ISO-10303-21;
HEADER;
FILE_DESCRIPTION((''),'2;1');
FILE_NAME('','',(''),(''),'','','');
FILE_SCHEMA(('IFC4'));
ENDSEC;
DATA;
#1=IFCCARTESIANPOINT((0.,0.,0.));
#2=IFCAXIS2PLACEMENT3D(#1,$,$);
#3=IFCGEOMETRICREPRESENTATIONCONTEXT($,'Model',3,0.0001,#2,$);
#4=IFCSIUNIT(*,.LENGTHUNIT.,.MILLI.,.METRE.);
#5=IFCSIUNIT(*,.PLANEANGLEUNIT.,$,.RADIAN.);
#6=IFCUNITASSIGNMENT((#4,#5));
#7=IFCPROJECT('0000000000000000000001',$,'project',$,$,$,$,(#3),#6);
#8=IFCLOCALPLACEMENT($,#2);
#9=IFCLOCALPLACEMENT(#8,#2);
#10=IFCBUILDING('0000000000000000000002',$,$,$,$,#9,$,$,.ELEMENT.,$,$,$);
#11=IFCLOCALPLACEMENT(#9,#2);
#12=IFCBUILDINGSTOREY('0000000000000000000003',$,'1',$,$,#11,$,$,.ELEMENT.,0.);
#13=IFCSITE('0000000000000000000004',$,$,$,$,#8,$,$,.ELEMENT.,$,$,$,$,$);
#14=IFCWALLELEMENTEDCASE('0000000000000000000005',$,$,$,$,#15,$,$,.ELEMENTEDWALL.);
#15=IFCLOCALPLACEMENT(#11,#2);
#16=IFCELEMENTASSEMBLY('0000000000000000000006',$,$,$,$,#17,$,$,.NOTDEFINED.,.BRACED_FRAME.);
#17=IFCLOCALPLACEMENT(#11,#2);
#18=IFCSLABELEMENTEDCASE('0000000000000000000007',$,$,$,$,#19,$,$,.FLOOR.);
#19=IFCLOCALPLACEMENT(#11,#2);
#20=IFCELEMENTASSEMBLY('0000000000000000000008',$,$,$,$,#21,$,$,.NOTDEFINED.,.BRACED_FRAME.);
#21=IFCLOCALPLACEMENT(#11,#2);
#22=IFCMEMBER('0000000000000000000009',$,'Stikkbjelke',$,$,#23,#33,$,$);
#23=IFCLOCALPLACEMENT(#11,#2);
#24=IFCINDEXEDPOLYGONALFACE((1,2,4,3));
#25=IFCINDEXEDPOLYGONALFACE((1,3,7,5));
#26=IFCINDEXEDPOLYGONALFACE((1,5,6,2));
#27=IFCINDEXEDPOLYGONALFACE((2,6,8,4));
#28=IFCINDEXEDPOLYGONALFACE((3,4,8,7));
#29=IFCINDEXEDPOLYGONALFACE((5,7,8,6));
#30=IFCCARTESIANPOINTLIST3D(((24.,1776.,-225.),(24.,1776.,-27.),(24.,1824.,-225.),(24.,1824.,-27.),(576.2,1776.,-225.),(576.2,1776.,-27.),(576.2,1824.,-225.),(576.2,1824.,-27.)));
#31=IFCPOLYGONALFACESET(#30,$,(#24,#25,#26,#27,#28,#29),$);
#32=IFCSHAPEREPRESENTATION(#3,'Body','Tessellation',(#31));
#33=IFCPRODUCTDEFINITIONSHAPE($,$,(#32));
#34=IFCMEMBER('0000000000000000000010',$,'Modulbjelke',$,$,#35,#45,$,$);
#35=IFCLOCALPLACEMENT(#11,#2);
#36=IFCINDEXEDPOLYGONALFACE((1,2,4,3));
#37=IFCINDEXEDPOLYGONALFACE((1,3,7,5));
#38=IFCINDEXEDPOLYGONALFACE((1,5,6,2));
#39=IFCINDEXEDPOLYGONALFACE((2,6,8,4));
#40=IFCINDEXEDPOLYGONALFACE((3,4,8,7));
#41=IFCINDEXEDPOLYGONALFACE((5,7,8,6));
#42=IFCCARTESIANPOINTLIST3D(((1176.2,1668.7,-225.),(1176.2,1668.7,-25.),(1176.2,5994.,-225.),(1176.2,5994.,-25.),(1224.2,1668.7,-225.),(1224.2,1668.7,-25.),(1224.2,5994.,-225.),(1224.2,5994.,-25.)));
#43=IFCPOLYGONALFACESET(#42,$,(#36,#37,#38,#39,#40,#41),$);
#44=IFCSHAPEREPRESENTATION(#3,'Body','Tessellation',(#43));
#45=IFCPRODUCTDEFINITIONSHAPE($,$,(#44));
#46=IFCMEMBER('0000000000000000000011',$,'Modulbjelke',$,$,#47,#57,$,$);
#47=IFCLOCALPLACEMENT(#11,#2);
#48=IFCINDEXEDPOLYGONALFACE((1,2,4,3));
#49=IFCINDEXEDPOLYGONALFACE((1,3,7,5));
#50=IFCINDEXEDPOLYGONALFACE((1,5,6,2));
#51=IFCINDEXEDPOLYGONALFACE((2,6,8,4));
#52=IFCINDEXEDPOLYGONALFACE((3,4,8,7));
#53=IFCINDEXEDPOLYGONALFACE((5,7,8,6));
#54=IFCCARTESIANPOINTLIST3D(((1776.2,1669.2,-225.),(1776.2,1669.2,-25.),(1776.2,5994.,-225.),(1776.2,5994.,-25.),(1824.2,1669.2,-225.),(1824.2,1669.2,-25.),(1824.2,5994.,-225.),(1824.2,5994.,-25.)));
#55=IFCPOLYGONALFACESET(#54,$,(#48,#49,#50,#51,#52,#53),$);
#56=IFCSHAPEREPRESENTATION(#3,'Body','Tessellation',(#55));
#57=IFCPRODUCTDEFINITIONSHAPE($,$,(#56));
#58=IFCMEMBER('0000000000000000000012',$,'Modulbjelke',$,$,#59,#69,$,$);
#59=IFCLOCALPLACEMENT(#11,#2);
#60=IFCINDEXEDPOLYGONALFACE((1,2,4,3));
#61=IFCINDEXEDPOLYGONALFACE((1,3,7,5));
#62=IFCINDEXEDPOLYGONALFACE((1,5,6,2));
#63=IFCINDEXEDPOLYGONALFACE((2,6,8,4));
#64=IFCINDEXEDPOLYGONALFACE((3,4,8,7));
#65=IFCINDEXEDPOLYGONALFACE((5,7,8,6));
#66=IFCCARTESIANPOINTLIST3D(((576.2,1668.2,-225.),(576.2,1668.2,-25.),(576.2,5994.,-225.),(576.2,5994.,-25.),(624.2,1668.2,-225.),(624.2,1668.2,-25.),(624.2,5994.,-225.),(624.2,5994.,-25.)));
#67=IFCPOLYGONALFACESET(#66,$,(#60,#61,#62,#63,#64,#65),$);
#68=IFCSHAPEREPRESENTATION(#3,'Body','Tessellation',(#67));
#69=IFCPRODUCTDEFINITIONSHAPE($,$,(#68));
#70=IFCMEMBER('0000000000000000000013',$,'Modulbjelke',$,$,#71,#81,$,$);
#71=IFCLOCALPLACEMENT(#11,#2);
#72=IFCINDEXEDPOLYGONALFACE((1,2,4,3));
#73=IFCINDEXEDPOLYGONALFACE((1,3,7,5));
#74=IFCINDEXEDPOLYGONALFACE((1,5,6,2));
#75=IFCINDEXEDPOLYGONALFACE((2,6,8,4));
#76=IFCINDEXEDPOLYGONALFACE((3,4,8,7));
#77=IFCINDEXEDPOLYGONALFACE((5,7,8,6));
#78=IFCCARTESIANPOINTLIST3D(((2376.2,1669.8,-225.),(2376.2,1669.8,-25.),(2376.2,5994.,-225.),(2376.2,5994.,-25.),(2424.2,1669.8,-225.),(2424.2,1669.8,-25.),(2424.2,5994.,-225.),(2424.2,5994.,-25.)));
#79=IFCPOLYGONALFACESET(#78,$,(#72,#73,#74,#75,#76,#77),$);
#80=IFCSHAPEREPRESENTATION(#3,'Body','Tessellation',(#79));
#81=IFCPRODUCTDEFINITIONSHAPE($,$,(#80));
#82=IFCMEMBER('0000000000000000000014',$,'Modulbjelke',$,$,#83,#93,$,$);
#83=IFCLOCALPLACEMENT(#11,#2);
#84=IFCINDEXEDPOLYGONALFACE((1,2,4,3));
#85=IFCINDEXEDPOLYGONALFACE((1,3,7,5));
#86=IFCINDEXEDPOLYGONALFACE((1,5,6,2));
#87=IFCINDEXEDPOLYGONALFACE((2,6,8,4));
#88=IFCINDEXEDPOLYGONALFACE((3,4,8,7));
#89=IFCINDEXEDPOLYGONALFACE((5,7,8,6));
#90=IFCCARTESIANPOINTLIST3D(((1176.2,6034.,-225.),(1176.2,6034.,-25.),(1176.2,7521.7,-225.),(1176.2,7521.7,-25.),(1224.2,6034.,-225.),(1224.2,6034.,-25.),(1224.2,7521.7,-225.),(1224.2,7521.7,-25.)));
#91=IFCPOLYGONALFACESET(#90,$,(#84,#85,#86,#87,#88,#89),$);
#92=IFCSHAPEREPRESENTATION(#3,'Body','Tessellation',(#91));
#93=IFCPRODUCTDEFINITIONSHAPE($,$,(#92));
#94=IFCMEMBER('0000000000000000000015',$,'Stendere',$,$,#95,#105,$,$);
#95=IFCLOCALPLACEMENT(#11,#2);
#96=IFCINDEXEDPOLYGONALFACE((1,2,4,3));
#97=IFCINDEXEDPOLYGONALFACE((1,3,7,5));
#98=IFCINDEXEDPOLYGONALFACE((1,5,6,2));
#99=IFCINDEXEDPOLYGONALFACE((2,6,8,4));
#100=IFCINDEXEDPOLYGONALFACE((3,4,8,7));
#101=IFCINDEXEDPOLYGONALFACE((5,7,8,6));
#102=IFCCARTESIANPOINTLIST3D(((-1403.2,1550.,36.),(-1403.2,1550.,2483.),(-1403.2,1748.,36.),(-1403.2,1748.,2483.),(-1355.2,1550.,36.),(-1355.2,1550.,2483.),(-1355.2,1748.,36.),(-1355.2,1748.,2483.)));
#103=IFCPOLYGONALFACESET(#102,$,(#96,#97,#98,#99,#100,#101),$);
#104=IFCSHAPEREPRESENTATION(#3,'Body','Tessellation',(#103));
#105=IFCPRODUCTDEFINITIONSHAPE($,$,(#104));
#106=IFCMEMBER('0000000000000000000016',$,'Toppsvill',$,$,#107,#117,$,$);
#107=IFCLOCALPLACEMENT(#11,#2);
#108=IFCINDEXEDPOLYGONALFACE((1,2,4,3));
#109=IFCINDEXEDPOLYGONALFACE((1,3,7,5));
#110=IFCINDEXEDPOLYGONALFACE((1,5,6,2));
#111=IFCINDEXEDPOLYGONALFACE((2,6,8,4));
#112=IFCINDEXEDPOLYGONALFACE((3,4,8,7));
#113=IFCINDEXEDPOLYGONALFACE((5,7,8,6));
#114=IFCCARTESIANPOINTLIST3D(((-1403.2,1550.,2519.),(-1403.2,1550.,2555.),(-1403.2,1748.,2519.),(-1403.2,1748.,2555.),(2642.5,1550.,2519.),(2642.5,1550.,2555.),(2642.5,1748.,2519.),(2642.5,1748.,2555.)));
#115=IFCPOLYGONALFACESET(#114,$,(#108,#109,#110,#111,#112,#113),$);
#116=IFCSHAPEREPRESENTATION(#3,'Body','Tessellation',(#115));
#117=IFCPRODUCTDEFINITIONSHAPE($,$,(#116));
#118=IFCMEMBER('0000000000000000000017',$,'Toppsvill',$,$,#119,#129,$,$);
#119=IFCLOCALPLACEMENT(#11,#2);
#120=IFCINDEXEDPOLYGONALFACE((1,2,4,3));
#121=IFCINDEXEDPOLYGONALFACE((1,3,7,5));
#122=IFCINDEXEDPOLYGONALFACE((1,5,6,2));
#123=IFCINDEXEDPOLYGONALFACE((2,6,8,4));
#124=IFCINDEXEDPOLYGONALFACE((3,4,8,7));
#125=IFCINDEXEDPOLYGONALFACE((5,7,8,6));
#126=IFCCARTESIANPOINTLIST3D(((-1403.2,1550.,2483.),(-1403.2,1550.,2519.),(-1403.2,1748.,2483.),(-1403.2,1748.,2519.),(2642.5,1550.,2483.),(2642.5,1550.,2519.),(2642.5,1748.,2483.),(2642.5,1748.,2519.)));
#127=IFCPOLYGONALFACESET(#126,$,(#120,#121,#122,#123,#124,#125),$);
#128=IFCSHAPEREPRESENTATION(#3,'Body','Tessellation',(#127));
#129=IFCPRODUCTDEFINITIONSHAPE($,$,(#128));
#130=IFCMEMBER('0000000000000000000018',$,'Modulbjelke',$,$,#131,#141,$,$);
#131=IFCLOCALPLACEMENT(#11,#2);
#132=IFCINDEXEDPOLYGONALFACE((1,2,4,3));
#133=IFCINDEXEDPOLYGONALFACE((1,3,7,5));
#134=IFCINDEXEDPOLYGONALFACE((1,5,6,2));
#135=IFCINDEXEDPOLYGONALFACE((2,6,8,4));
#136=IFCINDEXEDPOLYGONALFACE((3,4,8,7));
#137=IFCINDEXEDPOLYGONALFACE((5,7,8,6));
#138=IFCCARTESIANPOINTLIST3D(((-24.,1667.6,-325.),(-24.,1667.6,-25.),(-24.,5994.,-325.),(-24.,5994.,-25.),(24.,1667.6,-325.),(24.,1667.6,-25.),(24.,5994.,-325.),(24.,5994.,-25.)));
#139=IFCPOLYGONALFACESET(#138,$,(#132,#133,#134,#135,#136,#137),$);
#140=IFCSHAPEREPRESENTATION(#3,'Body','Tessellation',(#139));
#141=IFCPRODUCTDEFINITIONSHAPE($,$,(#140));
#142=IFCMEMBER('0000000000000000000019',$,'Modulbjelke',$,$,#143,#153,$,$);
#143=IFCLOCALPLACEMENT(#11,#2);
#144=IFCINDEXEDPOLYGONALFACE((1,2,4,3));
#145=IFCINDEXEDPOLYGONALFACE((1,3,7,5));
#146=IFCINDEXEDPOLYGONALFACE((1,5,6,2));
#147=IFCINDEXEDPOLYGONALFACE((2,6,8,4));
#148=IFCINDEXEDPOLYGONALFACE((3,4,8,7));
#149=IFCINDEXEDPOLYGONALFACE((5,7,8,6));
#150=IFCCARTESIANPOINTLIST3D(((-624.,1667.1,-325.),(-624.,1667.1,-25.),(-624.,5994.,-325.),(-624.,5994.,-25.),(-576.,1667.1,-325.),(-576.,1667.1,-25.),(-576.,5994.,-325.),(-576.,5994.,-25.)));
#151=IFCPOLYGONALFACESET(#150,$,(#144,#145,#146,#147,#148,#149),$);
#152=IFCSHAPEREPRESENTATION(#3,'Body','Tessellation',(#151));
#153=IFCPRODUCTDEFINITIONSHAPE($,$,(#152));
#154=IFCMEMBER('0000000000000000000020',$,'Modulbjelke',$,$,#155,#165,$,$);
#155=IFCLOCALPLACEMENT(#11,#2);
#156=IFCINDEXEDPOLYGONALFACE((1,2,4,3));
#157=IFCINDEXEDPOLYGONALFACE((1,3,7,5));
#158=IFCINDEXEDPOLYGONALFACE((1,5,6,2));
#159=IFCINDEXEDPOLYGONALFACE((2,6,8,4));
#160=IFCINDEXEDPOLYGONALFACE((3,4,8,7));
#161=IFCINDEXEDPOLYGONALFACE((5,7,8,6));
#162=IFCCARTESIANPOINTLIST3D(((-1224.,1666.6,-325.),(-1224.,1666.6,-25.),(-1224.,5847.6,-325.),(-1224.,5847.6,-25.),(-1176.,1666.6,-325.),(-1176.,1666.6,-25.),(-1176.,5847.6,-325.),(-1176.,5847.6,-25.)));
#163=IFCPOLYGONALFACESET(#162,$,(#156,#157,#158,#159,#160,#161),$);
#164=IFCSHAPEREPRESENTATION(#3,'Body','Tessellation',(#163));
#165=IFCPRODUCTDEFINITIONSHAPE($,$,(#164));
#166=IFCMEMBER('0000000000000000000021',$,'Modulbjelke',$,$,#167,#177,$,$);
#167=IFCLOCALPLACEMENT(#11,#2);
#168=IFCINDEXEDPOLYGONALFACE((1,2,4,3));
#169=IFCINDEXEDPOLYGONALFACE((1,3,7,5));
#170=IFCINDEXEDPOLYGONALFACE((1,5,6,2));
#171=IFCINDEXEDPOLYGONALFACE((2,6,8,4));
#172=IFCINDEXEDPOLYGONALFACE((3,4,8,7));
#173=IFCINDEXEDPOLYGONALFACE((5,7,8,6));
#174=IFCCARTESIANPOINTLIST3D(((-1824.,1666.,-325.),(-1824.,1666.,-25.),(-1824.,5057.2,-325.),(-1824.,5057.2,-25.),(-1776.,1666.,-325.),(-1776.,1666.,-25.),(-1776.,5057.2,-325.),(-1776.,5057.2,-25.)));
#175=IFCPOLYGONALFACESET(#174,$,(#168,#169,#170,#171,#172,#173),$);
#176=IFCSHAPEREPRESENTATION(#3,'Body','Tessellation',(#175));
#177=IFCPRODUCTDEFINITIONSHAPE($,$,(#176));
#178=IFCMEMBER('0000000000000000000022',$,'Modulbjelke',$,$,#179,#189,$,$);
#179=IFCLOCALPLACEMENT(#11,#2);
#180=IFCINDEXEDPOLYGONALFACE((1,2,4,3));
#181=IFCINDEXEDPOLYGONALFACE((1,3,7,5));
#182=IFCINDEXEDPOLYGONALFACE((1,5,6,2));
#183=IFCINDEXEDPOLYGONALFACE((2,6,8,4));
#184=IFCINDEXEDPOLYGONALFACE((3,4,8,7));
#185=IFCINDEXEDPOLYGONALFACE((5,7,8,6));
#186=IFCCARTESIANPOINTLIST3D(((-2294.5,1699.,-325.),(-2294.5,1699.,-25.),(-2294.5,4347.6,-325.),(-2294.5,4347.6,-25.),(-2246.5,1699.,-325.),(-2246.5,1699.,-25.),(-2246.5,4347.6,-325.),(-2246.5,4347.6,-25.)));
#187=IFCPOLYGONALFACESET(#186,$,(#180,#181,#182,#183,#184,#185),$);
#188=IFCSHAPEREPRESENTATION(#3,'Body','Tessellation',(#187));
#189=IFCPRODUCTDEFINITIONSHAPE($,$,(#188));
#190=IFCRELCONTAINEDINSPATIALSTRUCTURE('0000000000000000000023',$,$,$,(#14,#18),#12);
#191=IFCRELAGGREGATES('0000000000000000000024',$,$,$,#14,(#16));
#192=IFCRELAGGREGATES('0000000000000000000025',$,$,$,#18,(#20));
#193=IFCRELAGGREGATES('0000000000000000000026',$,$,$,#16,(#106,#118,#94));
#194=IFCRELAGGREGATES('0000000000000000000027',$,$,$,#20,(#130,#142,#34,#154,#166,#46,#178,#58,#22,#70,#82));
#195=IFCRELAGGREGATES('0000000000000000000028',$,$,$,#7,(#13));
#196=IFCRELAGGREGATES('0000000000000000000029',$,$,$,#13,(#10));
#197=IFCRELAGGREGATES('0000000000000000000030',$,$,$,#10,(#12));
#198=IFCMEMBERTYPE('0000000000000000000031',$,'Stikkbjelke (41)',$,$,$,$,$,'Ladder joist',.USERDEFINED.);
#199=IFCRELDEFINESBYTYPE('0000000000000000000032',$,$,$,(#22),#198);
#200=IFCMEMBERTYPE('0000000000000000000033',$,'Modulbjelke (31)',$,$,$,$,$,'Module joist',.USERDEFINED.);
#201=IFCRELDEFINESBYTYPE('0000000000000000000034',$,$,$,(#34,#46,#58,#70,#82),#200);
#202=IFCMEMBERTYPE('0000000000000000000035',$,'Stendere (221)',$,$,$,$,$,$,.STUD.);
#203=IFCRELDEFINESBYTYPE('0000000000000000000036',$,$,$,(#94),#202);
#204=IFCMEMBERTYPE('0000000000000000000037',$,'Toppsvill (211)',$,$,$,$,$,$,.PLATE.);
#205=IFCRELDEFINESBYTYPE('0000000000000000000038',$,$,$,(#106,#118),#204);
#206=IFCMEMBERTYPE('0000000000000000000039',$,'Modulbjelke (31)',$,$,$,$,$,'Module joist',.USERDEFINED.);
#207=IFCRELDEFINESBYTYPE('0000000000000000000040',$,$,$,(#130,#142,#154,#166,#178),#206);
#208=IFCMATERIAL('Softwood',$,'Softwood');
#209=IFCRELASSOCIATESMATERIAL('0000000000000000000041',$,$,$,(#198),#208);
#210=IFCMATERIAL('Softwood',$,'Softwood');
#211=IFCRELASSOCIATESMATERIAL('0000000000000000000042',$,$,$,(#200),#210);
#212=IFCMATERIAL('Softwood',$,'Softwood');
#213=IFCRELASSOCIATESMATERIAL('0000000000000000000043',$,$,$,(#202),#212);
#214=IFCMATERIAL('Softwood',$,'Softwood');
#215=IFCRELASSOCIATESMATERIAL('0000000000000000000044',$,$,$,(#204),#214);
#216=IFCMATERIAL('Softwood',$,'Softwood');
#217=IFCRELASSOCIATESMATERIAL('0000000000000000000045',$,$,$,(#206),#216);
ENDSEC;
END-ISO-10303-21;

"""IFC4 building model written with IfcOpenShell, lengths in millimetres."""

from ifc_helpers import new_model, si_unit, frame, origin, place, context, project, spatial, rectangle, extrude, clip, halfspace, material, material_profile, profile_set, type_object, element, aggregate, save


model = new_model("IFC4")

# Units and contexts
model_context = context("Model", 3, precision=0.0001, world=origin())
ifc_project = project(units=[si_unit("LENGTHUNIT", "METRE", prefix="MILLI"), si_unit("PLANEANGLEUNIT", "RADIAN")], contexts=[model_context])

# Site, building, storey
site_placement = place(None, origin())
site = spatial("IfcSite", under=ifc_project, at=site_placement, CompositionType="ELEMENT")
building_placement = place(site_placement, origin())
building = spatial("IfcBuilding", under=site, at=building_placement, CompositionType="ELEMENT")
storey_placement = place(building_placement, origin())
storey = spatial("IfcBuildingStorey", under=building, at=storey_placement, Name="1", CompositionType="ELEMENT", Elevation=0.0)

# Wall, element assembly
wall_placement = place(storey_placement, frame((-1403.2, 1748.0, 0.0), z_axis=(0.0, -1.0, 0.0)))
wall = element("IfcWallElementedCase", 1, at=wall_placement, inside=storey, PredefinedType="ELEMENTEDWALL")
assembly_1_placement = place(wall_placement, origin())
assembly_1 = element("IfcElementAssembly", 2, at=assembly_1_placement, AssemblyPlace="NOTDEFINED", PredefinedType="BRACED_FRAME")
aggregate(wall, [assembly_1])

# Slab, element assembly, members
slab_placement = place(storey_placement, origin())
slab = element("IfcSlabElementedCase", 3, at=slab_placement, inside=storey, PredefinedType="FLOOR")
assembly_2_placement = place(slab_placement, frame((0.0, 0.0, -225.0)))
assembly_2 = element("IfcElementAssembly", 4, at=assembly_2_placement, AssemblyPlace="NOTDEFINED", PredefinedType="BRACED_FRAME")
aggregate(slab, [assembly_2])
ifc_material_1 = material(Name="Softwood", Category="Softwood")
ifc_material_profile_1 = material_profile(ifc_material_1, rectangle(XDim=48.0, YDim=198.0), Name="Stikkbjelke (41)")
ifc_profile_set_1 = profile_set([ifc_material_profile_1])
member_type_1 = type_object("IfcMemberType", Name="Stikkbjelke (41)", ElementType="Ladder joist", PredefinedType="USERDEFINED", material=ifc_profile_set_1)
member_1_placement = place(assembly_2_placement, frame((24.0, 1800.0, 0.0), z_axis=(1.0, 0.0, 0.0), x_axis=(0.0, 1.0, 0.0)))
member_1 = element("IfcMember", 5, at=member_1_placement, type_object=member_type_1, Name="Stikkbjelke", context=model_context, shape_type="SweptSolid", body=[
    extrude(rectangle(XDim=48.0, YDim=198.0), frame((0.0, 99.0, 0.0)), (0.0, 0.0, 1.0), 552.2),
])
ifc_material_2 = material(Name="Softwood", Category="Softwood")
ifc_material_profile_2 = material_profile(ifc_material_2, rectangle(XDim=48.0, YDim=200.0), Name="Modulbjelke (31)")
ifc_profile_set_2 = profile_set([ifc_material_profile_2])
member_type_2 = type_object("IfcMemberType", Name="Modulbjelke (31)", ElementType="Module joist", PredefinedType="USERDEFINED", material=ifc_profile_set_2)
member_2_placement = place(assembly_2_placement, frame((1200.2, 1668.7, 0.0), z_axis=(0.0, 1.0, 0.0), x_axis=(-1.0, 0.0, 0.0)))
member_2 = element("IfcMember", 6, at=member_2_placement, type_object=member_type_2, Name="Modulbjelke", context=model_context, shape_type="SweptSolid", body=[
    extrude(rectangle(XDim=48.0, YDim=200.0), frame((0.0, 100.0, 0.0)), (0.0, 0.0, 1.0), 4325.3),
])
member_3_placement = place(assembly_2_placement, frame((1800.2, 1669.2, 0.0), z_axis=(0.0, 1.0, 0.0), x_axis=(-1.0, 0.0, 0.0)))
member_3 = element("IfcMember", 7, at=member_3_placement, type_object=member_type_2, Name="Modulbjelke", context=model_context, shape_type="SweptSolid", body=[
    extrude(rectangle(XDim=48.0, YDim=200.0), frame((0.0, 100.0, 0.0)), (0.0, 0.0, 1.0), 4324.8),
])
member_4_placement = place(assembly_2_placement, frame((600.2, 1668.2, 0.0), z_axis=(0.0, 1.0, 0.0), x_axis=(-1.0, 0.0, 0.0)))
member_4 = element("IfcMember", 8, at=member_4_placement, type_object=member_type_2, Name="Modulbjelke", context=model_context, shape_type="SweptSolid", body=[
    extrude(rectangle(XDim=48.0, YDim=200.0), frame((0.0, 100.0, 0.0)), (0.0, 0.0, 1.0), 4325.8),
])
member_5_placement = place(assembly_2_placement, frame((2400.2, 1669.8, 0.0), z_axis=(0.0, 1.0, 0.0), x_axis=(-1.0, 0.0, 0.0)))
member_5 = element("IfcMember", 9, at=member_5_placement, type_object=member_type_2, Name="Modulbjelke", context=model_context, shape_type="SweptSolid", body=[
    extrude(rectangle(XDim=48.0, YDim=200.0), frame((0.0, 100.0, 0.0)), (0.0, 0.0, 1.0), 4324.2),
])
member_6_placement = place(assembly_2_placement, frame((1200.2, 6034.0, 0.0), z_axis=(0.000001, 1.0, 0.0), x_axis=(-1.0, 0.000001, 0.0)))
member_6 = element("IfcMember", 10, at=member_6_placement, type_object=member_type_2, Name="Modulbjelke", context=model_context, shape_type="Clipping", body=[
    clip(clip(extrude(rectangle(XDim=48.0, YDim=200.0), frame((0.0, 100.0, 0.0)), (0.0, 0.0, 1.0), 1487.7), halfspace(frame((0.0, 100.0, 0.0)), True)), halfspace(frame((0.0, 100.0, 1487.7)), False)),
])

# Members
ifc_material_3 = material(Name="Softwood", Category="Softwood")
ifc_material_profile_3 = material_profile(ifc_material_3, rectangle(XDim=48.0, YDim=198.0), Name="Stendere (221)")
ifc_profile_set_3 = profile_set([ifc_material_profile_3])
member_type_3 = type_object("IfcMemberType", Name="Stendere (221)", PredefinedType="STUD", material=ifc_profile_set_3)
member_7_placement = place(assembly_1_placement, frame((24.0, 36.0, 0.0), z_axis=(0.0, 1.0, 0.0), x_axis=(-1.0, 0.0, 0.0)))
member_7 = element("IfcMember", 11, at=member_7_placement, type_object=member_type_3, Name="Stendere", context=model_context, shape_type="SweptSolid", body=[
    extrude(rectangle(XDim=48.0, YDim=198.0), frame((0.0, 99.0, 0.0)), (0.0, 0.0, 1.0), 2447.0),
])
ifc_material_4 = material(Name="Softwood", Category="Softwood")
ifc_material_profile_4 = material_profile(ifc_material_4, rectangle(XDim=36.0, YDim=198.0), Name="Toppsvill (211)")
ifc_profile_set_4 = profile_set([ifc_material_profile_4])
member_type_4 = type_object("IfcMemberType", Name="Toppsvill (211)", PredefinedType="PLATE", material=ifc_profile_set_4)
member_8_placement = place(assembly_1_placement, frame((0.0, 2537.0, 0.0), z_axis=(1.0, 0.0, 0.0), x_axis=(0.0, 1.0, 0.0)))
member_8 = element("IfcMember", 12, at=member_8_placement, type_object=member_type_4, Name="Toppsvill", context=model_context, shape_type="SweptSolid", body=[
    extrude(rectangle(XDim=36.0, YDim=198.0), frame((0.0, 99.0, 0.0)), (0.0, 0.0, 1.0), 4045.7),
])
member_9_placement = place(assembly_1_placement, frame((0.0, 2501.0, 0.0), z_axis=(1.0, 0.0, 0.0), x_axis=(0.0, 1.0, 0.0)))
member_9 = element("IfcMember", 13, at=member_9_placement, type_object=member_type_4, Name="Toppsvill", context=model_context, shape_type="SweptSolid", body=[
    extrude(rectangle(XDim=36.0, YDim=198.0), frame((0.0, 99.0, 0.0)), (0.0, 0.0, 1.0), 4045.7),
])
aggregate(assembly_1, [member_8, member_9, member_7])
ifc_material_5 = material(Name="Softwood", Category="Softwood")
ifc_material_profile_5 = material_profile(ifc_material_5, rectangle(XDim=48.0, YDim=300.0), Name="Modulbjelke (31)")
ifc_profile_set_5 = profile_set([ifc_material_profile_5])
member_type_5 = type_object("IfcMemberType", Name="Modulbjelke (31)", ElementType="Module joist", PredefinedType="USERDEFINED", material=ifc_profile_set_5)
member_10_placement = place(assembly_2_placement, frame((0.0, 1667.6, -100.0), z_axis=(0.0, 1.0, 0.0), x_axis=(-1.0, 0.0, 0.0)))
member_10 = element("IfcMember", 14, at=member_10_placement, type_object=member_type_5, Name="Modulbjelke", context=model_context, shape_type="SweptSolid", body=[
    extrude(rectangle(XDim=48.0, YDim=300.0), frame((0.0, 150.0, 0.0)), (0.0, 0.0, 1.0), 4326.4),
])
member_11_placement = place(assembly_2_placement, frame((-600.0, 1667.1, -100.0), z_axis=(0.0, 1.0, 0.0), x_axis=(-1.0, 0.0, 0.0)))
member_11 = element("IfcMember", 15, at=member_11_placement, type_object=member_type_5, Name="Modulbjelke", context=model_context, shape_type="SweptSolid", body=[
    extrude(rectangle(XDim=48.0, YDim=300.0), frame((0.0, 150.0, 0.0)), (0.0, 0.0, 1.0), 4326.9),
])
member_12_placement = place(assembly_2_placement, frame((-1200.0, 1666.6, -100.0), z_axis=(0.0, 1.0, 0.0), x_axis=(-1.0, 0.0, 0.0)))
member_12 = element("IfcMember", 16, at=member_12_placement, type_object=member_type_5, Name="Modulbjelke", context=model_context, shape_type="SweptSolid", body=[
    extrude(rectangle(XDim=48.0, YDim=300.0), frame((0.0, 150.0, 0.0)), (0.0, 0.0, 1.0), 4181.0),
])
member_13_placement = place(assembly_2_placement, frame((-1800.0, 1666.0, -100.0), z_axis=(0.0, 1.0, 0.0), x_axis=(-1.0, 0.0, 0.0)))
member_13 = element("IfcMember", 17, at=member_13_placement, type_object=member_type_5, Name="Modulbjelke", context=model_context, shape_type="SweptSolid", body=[
    extrude(rectangle(XDim=48.0, YDim=300.0), frame((0.0, 150.0, 0.0)), (0.0, 0.0, 1.0), 3391.2),
])
member_14_placement = place(assembly_2_placement, frame((-2270.5, 1699.0, -100.0), z_axis=(0.0, 1.0, 0.0), x_axis=(-1.0, 0.0, 0.0)))
member_14 = element("IfcMember", 18, at=member_14_placement, type_object=member_type_5, Name="Modulbjelke", context=model_context, shape_type="SweptSolid", body=[
    extrude(rectangle(XDim=48.0, YDim=300.0), frame((0.0, 150.0, 0.0)), (0.0, 0.0, 1.0), 2648.6),
])

aggregate(assembly_2, [member_10, member_11, member_2, member_12, member_13, member_3, member_14, member_4, member_1, member_5, member_6])

save(model, "model.ifc")
